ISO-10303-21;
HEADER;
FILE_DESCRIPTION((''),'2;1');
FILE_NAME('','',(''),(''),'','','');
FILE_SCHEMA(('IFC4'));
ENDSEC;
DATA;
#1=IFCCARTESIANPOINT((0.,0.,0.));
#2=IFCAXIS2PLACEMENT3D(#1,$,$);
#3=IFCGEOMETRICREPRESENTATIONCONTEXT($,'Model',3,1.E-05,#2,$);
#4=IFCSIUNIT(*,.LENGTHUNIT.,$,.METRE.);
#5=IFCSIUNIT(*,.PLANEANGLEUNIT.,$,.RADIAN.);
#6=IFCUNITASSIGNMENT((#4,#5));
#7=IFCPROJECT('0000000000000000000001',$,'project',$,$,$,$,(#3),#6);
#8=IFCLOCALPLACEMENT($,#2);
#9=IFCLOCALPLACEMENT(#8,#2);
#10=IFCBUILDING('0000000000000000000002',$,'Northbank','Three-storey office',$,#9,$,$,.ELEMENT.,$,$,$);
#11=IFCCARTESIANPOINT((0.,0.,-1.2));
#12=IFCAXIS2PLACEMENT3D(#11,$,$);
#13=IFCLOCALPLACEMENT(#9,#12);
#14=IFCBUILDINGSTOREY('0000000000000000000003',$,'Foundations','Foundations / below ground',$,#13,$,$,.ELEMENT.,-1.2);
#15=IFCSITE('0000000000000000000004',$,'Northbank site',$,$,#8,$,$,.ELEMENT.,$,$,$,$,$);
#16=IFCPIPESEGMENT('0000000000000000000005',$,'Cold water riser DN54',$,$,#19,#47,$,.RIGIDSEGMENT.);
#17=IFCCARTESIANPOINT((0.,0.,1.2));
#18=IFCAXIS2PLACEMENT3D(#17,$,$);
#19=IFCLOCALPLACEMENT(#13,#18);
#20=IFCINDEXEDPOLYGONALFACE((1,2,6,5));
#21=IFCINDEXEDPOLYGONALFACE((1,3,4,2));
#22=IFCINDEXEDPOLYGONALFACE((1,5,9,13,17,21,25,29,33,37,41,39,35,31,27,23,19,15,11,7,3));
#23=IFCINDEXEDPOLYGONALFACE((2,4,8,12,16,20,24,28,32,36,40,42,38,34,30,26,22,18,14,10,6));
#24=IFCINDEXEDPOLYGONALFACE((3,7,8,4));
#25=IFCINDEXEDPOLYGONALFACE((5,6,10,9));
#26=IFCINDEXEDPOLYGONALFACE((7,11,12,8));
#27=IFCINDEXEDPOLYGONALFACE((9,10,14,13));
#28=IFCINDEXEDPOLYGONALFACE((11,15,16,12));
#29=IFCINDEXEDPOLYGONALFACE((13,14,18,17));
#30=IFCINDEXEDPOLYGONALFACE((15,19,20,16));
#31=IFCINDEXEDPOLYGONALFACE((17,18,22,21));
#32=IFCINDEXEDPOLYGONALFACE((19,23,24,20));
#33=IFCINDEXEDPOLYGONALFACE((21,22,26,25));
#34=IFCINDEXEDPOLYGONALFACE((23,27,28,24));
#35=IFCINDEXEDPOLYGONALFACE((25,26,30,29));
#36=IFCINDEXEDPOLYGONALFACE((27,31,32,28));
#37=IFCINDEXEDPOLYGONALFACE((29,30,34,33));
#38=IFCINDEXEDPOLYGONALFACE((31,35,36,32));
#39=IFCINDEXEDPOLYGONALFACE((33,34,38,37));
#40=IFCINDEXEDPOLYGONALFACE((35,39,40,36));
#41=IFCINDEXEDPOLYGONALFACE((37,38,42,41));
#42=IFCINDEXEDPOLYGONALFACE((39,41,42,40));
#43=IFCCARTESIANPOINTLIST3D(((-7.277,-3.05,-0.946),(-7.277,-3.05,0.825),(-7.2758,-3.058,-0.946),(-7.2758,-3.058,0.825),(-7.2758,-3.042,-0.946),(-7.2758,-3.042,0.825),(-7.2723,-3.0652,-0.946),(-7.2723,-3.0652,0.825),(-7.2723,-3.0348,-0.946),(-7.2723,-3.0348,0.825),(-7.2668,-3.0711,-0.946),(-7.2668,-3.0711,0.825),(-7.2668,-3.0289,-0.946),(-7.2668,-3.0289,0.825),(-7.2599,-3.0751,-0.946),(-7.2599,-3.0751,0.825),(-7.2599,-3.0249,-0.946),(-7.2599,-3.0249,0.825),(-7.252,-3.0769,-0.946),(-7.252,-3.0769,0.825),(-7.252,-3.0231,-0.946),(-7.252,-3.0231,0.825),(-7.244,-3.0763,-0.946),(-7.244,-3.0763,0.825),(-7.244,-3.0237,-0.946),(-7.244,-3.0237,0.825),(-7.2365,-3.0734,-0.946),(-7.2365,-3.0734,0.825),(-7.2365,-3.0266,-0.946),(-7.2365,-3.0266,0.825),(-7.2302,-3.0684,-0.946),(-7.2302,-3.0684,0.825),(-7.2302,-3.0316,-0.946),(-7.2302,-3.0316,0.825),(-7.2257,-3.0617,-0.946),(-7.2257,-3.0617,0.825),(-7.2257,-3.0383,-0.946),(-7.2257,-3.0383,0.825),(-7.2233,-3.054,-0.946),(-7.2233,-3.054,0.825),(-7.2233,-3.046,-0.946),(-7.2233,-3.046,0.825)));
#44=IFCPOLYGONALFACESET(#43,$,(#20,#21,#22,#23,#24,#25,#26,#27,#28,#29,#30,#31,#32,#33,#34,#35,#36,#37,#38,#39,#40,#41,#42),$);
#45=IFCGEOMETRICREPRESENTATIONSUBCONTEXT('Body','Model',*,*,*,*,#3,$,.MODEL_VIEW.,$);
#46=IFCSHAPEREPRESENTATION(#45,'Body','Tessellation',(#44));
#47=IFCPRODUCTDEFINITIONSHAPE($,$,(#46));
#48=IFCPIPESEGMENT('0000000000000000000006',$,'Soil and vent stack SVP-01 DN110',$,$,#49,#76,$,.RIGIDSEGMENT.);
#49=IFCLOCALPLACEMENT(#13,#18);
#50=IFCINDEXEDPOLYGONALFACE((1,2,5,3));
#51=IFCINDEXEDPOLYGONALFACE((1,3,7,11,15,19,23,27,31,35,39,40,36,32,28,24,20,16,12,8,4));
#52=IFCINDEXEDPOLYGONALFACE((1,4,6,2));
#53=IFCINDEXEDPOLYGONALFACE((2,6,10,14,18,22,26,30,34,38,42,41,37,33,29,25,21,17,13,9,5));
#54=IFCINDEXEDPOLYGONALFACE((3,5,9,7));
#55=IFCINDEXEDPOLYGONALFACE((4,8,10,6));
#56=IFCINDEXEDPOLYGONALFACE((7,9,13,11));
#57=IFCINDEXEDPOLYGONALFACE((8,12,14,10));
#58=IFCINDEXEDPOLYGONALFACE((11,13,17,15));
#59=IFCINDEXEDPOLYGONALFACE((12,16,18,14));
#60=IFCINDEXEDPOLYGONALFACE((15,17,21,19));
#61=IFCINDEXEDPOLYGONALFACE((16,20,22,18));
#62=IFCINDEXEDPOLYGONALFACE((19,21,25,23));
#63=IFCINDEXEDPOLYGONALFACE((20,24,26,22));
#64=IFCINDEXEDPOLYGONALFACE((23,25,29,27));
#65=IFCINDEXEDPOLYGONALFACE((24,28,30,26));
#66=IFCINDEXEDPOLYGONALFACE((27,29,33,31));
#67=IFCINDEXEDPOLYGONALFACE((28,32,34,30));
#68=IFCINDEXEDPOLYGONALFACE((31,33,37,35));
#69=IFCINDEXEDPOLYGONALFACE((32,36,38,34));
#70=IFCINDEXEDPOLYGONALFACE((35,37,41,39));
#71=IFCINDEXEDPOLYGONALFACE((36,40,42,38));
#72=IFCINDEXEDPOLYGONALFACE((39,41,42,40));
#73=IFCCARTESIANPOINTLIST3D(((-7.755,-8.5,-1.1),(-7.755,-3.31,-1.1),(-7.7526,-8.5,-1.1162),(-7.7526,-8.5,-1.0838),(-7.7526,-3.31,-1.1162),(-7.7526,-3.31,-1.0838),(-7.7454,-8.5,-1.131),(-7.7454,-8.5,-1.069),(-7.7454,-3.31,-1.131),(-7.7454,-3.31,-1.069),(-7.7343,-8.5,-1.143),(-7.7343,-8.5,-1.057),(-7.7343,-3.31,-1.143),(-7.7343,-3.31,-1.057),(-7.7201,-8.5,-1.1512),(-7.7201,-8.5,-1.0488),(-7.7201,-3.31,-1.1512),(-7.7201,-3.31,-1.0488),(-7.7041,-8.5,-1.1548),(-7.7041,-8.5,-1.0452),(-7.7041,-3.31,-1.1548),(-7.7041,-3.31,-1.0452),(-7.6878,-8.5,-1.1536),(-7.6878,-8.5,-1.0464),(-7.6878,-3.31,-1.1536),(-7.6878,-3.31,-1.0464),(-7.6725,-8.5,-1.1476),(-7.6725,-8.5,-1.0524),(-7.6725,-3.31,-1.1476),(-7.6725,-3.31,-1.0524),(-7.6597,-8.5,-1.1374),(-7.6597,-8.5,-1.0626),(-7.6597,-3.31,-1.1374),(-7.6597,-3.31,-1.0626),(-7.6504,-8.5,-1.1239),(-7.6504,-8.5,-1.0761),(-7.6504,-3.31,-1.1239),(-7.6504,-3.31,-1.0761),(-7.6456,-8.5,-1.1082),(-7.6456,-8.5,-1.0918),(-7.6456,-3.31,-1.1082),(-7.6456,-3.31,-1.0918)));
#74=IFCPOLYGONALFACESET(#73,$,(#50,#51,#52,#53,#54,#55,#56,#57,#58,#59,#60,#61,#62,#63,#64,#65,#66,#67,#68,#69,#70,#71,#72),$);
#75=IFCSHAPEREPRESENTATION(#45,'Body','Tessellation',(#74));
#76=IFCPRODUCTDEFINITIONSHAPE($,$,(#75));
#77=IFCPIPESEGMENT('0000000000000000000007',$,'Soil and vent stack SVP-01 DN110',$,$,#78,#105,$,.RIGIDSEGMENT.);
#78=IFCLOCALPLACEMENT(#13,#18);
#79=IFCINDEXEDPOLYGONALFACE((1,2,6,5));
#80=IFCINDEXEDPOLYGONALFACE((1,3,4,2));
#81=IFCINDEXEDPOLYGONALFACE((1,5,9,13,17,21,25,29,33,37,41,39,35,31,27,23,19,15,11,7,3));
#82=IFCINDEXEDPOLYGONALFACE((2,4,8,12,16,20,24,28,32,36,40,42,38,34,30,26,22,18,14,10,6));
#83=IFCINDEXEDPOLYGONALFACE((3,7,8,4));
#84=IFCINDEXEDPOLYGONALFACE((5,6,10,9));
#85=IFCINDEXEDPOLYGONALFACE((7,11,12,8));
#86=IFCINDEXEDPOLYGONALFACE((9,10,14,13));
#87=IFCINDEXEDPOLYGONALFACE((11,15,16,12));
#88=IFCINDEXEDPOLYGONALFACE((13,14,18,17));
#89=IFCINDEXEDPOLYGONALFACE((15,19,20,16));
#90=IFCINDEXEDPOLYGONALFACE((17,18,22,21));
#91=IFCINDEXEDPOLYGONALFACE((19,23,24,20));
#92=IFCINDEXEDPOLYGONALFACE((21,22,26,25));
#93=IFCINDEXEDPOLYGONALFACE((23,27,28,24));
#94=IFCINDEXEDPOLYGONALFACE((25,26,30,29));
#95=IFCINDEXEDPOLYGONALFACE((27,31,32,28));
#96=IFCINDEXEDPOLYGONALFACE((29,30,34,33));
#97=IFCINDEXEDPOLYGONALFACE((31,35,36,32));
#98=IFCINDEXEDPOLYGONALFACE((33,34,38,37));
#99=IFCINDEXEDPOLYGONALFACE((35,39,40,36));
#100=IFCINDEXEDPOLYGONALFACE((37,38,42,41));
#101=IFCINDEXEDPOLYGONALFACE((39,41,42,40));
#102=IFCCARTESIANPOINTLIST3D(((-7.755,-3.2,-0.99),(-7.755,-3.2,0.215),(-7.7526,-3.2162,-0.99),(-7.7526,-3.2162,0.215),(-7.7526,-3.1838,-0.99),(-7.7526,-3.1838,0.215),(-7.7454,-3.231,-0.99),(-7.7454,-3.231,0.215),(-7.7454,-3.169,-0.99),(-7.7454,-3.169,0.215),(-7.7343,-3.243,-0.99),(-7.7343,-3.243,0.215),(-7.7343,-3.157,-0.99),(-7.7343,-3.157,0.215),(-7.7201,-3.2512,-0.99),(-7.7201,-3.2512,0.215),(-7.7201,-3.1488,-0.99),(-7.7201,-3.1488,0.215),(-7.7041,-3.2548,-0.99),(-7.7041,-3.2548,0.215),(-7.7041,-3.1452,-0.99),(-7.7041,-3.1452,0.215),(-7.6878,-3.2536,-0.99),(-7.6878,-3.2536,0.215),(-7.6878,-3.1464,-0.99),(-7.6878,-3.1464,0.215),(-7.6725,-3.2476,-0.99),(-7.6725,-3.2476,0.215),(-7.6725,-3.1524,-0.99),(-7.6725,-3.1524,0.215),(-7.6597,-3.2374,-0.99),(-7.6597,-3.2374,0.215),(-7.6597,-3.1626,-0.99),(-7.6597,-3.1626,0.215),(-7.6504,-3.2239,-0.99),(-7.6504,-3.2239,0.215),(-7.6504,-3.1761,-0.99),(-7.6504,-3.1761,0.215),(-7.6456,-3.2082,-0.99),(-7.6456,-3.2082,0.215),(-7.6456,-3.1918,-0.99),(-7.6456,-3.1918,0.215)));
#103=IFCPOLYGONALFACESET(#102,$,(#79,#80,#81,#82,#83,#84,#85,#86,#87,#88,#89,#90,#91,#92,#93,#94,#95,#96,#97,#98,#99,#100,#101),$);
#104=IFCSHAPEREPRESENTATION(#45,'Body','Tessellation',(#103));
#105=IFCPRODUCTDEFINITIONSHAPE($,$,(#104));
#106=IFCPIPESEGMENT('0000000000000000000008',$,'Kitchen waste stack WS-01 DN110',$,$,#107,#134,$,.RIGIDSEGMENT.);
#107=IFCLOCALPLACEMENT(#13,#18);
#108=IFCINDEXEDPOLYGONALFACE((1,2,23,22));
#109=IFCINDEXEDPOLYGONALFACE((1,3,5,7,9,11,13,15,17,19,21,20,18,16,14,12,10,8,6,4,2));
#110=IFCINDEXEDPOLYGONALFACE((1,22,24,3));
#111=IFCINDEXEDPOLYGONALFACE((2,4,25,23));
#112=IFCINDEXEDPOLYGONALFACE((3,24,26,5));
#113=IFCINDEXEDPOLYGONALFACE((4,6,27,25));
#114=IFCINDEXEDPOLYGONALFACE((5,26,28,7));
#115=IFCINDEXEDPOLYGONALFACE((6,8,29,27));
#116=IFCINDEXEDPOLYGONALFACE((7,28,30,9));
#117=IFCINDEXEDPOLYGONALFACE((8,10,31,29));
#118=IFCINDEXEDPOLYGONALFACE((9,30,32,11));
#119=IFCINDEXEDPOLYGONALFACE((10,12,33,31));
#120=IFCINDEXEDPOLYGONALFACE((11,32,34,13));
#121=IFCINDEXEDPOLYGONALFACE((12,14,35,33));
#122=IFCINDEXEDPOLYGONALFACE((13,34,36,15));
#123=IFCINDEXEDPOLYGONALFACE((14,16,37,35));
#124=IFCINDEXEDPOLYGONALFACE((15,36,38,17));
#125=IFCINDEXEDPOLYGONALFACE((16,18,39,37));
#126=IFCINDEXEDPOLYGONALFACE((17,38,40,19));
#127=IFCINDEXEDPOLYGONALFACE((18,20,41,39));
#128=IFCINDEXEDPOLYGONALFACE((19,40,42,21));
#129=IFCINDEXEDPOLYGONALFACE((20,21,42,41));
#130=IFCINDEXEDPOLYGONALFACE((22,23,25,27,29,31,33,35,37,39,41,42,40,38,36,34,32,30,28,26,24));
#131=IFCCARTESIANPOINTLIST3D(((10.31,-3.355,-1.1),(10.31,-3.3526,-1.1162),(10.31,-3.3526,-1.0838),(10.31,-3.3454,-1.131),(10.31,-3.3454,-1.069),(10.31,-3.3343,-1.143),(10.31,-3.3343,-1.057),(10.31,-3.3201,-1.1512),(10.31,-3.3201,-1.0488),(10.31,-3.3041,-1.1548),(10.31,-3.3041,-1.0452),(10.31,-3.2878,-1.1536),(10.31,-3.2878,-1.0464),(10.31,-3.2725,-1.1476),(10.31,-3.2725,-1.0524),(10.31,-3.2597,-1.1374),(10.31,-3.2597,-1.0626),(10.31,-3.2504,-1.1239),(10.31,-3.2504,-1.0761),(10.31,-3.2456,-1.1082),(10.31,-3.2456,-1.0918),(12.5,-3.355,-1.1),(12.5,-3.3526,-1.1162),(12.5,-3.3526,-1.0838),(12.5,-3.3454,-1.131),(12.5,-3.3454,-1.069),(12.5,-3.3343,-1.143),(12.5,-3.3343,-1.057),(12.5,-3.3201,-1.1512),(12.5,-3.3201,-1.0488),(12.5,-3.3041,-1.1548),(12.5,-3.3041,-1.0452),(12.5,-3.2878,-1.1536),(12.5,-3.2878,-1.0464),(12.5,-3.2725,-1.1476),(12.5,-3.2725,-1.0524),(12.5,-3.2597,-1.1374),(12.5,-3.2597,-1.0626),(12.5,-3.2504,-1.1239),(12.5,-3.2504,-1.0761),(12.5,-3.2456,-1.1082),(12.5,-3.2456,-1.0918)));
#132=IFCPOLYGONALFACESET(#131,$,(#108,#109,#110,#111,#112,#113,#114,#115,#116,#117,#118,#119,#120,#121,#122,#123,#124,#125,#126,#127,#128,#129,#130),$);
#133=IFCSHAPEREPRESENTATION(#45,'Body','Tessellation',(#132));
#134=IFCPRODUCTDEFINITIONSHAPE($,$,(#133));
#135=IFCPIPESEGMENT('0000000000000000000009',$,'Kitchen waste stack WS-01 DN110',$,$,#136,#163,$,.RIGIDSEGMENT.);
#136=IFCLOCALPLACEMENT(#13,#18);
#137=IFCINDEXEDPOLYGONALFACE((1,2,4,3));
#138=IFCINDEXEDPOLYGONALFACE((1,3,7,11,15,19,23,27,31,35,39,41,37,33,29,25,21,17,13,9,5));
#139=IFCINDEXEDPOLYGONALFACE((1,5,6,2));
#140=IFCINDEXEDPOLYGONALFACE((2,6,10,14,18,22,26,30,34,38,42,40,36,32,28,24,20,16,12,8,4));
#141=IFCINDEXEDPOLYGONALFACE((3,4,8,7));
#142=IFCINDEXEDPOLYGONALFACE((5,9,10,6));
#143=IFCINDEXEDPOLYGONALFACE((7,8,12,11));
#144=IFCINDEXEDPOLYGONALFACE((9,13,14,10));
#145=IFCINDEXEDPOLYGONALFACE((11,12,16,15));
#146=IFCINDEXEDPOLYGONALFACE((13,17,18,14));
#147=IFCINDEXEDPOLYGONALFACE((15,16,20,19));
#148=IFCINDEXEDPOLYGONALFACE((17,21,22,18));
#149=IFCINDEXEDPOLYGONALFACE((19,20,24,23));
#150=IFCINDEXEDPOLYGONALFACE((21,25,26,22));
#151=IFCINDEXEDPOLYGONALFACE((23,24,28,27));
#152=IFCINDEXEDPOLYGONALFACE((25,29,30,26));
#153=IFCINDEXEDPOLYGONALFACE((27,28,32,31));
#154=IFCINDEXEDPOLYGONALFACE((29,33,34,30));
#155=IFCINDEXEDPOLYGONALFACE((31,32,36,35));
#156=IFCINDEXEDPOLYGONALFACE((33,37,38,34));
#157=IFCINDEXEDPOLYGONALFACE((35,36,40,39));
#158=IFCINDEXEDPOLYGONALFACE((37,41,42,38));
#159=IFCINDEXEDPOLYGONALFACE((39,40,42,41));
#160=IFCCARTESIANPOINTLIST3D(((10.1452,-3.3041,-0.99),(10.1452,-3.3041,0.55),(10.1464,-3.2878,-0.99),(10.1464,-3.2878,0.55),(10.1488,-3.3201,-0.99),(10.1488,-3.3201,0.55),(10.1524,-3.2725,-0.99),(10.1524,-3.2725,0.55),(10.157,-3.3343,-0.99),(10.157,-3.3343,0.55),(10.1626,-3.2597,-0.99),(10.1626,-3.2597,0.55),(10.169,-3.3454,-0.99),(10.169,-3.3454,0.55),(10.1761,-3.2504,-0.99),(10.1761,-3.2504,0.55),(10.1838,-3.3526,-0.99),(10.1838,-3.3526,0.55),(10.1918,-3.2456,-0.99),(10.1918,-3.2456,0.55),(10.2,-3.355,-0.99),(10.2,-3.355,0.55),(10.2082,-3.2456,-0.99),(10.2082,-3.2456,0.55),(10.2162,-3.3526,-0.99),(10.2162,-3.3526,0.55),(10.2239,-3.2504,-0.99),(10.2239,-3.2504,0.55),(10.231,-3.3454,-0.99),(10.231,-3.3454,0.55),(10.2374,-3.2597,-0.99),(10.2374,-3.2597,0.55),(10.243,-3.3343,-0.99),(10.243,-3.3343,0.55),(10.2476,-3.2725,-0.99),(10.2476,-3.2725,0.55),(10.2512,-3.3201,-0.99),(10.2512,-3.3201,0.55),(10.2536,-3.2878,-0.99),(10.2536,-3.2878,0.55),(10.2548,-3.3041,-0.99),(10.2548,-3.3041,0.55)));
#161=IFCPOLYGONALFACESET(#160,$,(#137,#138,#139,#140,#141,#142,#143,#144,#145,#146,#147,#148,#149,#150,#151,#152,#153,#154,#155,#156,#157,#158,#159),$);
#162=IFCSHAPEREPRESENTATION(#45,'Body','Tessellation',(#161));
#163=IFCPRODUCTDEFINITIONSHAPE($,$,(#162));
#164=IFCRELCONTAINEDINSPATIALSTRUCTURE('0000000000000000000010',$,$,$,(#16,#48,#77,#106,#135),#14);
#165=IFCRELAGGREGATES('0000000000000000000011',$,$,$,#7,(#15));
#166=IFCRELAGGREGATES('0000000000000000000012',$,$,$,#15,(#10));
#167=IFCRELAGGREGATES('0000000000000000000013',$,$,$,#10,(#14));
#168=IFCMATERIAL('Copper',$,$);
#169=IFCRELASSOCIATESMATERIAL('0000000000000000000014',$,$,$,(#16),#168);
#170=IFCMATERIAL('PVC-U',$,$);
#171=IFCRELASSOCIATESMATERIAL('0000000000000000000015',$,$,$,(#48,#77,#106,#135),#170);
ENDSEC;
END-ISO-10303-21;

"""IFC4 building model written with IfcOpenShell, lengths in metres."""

from ifc_helpers import new_model, si_unit, frame, origin, place, context, subcontext, project, spatial, circle, extrude, material, element, save


model = new_model("IFC4")

# Units and contexts
model_context = context("Model", 3, precision=1e-05, world=origin())
body_context = subcontext(model_context, "Body", "Model", "MODEL_VIEW")
ifc_project = project(units=[si_unit("LENGTHUNIT", "METRE"), si_unit("PLANEANGLEUNIT", "RADIAN")], contexts=[model_context])

# Site, building, storey
site_placement = place(None, origin())
site = spatial("IfcSite", under=ifc_project, at=site_placement, Name="Northbank site", CompositionType="ELEMENT")
building_placement = place(site_placement, origin())
building = spatial("IfcBuilding", under=site, at=building_placement, Name="Northbank", Description="Three-storey office", CompositionType="ELEMENT")
storey_placement = place(building_placement, frame((0.0, 0.0, -1.2)))
storey = spatial("IfcBuildingStorey", under=building, at=storey_placement, Name="Foundations", Description="Foundations / below ground", CompositionType="ELEMENT", Elevation=-1.2)

# Pipe segments
ifc_material_1 = material(Name="Copper")
pipe_segment_1_placement = place(storey_placement, frame((0.0, 0.0, 1.2)))
element("IfcPipeSegment", 1, at=pipe_segment_1_placement, inside=storey, material=ifc_material_1, Name="Cold water riser DN54", PredefinedType="RIGIDSEGMENT", context=body_context, shape_type="SweptSolid", body=[
    extrude(circle(Radius=0.027), frame((-7.25, -3.05, -0.946), z_axis=(0.0, 0.0, 1.0), x_axis=(-1.0, 0.0, 0.0)), (0.0, 0.0, 1.0), 1.771),
])
ifc_material_2 = material(Name="PVC-U")
pipe_segment_2_placement = place(storey_placement, frame((0.0, 0.0, 1.2)))
element("IfcPipeSegment", 2, at=pipe_segment_2_placement, inside=storey, material=ifc_material_2, Name="Soil and vent stack SVP-01 DN110", PredefinedType="RIGIDSEGMENT", context=body_context, shape_type="SweptSolid", body=[
    extrude(circle(Radius=0.055), frame((-7.7, -8.5, -1.1), z_axis=(0.0, 1.0, 0.0), x_axis=(-1.0, 0.0, 0.0)), (0.0, 0.0, 1.0), 5.19),
])
pipe_segment_3_placement = place(storey_placement, frame((0.0, 0.0, 1.2)))
element("IfcPipeSegment", 3, at=pipe_segment_3_placement, inside=storey, material=ifc_material_2, Name="Soil and vent stack SVP-01 DN110", PredefinedType="RIGIDSEGMENT", context=body_context, shape_type="SweptSolid", body=[
    extrude(circle(Radius=0.055), frame((-7.7, -3.2, -0.99), z_axis=(0.0, 0.0, 1.0), x_axis=(-1.0, 0.0, 0.0)), (0.0, 0.0, 1.0), 1.205),
])
pipe_segment_4_placement = place(storey_placement, frame((0.0, 0.0, 1.2)))
element("IfcPipeSegment", 4, at=pipe_segment_4_placement, inside=storey, material=ifc_material_2, Name="Kitchen waste stack WS-01 DN110", PredefinedType="RIGIDSEGMENT", context=body_context, shape_type="SweptSolid", body=[
    extrude(circle(Radius=0.055), frame((12.5, -3.3, -1.1), z_axis=(-1.0, 0.0, 0.0), x_axis=(0.0, -1.0, 0.0)), (0.0, 0.0, 1.0), 2.19),
])
pipe_segment_5_placement = place(storey_placement, frame((0.0, 0.0, 1.2)))
element("IfcPipeSegment", 5, at=pipe_segment_5_placement, inside=storey, material=ifc_material_2, Name="Kitchen waste stack WS-01 DN110", PredefinedType="RIGIDSEGMENT", context=body_context, shape_type="SweptSolid", body=[
    extrude(circle(Radius=0.055), frame((10.2, -3.3, -0.99), z_axis=(0.0, 0.0, 1.0), x_axis=(0.0, -1.0, 0.0)), (0.0, 0.0, 1.0), 1.54),
])

save(model, "model.ifc")
